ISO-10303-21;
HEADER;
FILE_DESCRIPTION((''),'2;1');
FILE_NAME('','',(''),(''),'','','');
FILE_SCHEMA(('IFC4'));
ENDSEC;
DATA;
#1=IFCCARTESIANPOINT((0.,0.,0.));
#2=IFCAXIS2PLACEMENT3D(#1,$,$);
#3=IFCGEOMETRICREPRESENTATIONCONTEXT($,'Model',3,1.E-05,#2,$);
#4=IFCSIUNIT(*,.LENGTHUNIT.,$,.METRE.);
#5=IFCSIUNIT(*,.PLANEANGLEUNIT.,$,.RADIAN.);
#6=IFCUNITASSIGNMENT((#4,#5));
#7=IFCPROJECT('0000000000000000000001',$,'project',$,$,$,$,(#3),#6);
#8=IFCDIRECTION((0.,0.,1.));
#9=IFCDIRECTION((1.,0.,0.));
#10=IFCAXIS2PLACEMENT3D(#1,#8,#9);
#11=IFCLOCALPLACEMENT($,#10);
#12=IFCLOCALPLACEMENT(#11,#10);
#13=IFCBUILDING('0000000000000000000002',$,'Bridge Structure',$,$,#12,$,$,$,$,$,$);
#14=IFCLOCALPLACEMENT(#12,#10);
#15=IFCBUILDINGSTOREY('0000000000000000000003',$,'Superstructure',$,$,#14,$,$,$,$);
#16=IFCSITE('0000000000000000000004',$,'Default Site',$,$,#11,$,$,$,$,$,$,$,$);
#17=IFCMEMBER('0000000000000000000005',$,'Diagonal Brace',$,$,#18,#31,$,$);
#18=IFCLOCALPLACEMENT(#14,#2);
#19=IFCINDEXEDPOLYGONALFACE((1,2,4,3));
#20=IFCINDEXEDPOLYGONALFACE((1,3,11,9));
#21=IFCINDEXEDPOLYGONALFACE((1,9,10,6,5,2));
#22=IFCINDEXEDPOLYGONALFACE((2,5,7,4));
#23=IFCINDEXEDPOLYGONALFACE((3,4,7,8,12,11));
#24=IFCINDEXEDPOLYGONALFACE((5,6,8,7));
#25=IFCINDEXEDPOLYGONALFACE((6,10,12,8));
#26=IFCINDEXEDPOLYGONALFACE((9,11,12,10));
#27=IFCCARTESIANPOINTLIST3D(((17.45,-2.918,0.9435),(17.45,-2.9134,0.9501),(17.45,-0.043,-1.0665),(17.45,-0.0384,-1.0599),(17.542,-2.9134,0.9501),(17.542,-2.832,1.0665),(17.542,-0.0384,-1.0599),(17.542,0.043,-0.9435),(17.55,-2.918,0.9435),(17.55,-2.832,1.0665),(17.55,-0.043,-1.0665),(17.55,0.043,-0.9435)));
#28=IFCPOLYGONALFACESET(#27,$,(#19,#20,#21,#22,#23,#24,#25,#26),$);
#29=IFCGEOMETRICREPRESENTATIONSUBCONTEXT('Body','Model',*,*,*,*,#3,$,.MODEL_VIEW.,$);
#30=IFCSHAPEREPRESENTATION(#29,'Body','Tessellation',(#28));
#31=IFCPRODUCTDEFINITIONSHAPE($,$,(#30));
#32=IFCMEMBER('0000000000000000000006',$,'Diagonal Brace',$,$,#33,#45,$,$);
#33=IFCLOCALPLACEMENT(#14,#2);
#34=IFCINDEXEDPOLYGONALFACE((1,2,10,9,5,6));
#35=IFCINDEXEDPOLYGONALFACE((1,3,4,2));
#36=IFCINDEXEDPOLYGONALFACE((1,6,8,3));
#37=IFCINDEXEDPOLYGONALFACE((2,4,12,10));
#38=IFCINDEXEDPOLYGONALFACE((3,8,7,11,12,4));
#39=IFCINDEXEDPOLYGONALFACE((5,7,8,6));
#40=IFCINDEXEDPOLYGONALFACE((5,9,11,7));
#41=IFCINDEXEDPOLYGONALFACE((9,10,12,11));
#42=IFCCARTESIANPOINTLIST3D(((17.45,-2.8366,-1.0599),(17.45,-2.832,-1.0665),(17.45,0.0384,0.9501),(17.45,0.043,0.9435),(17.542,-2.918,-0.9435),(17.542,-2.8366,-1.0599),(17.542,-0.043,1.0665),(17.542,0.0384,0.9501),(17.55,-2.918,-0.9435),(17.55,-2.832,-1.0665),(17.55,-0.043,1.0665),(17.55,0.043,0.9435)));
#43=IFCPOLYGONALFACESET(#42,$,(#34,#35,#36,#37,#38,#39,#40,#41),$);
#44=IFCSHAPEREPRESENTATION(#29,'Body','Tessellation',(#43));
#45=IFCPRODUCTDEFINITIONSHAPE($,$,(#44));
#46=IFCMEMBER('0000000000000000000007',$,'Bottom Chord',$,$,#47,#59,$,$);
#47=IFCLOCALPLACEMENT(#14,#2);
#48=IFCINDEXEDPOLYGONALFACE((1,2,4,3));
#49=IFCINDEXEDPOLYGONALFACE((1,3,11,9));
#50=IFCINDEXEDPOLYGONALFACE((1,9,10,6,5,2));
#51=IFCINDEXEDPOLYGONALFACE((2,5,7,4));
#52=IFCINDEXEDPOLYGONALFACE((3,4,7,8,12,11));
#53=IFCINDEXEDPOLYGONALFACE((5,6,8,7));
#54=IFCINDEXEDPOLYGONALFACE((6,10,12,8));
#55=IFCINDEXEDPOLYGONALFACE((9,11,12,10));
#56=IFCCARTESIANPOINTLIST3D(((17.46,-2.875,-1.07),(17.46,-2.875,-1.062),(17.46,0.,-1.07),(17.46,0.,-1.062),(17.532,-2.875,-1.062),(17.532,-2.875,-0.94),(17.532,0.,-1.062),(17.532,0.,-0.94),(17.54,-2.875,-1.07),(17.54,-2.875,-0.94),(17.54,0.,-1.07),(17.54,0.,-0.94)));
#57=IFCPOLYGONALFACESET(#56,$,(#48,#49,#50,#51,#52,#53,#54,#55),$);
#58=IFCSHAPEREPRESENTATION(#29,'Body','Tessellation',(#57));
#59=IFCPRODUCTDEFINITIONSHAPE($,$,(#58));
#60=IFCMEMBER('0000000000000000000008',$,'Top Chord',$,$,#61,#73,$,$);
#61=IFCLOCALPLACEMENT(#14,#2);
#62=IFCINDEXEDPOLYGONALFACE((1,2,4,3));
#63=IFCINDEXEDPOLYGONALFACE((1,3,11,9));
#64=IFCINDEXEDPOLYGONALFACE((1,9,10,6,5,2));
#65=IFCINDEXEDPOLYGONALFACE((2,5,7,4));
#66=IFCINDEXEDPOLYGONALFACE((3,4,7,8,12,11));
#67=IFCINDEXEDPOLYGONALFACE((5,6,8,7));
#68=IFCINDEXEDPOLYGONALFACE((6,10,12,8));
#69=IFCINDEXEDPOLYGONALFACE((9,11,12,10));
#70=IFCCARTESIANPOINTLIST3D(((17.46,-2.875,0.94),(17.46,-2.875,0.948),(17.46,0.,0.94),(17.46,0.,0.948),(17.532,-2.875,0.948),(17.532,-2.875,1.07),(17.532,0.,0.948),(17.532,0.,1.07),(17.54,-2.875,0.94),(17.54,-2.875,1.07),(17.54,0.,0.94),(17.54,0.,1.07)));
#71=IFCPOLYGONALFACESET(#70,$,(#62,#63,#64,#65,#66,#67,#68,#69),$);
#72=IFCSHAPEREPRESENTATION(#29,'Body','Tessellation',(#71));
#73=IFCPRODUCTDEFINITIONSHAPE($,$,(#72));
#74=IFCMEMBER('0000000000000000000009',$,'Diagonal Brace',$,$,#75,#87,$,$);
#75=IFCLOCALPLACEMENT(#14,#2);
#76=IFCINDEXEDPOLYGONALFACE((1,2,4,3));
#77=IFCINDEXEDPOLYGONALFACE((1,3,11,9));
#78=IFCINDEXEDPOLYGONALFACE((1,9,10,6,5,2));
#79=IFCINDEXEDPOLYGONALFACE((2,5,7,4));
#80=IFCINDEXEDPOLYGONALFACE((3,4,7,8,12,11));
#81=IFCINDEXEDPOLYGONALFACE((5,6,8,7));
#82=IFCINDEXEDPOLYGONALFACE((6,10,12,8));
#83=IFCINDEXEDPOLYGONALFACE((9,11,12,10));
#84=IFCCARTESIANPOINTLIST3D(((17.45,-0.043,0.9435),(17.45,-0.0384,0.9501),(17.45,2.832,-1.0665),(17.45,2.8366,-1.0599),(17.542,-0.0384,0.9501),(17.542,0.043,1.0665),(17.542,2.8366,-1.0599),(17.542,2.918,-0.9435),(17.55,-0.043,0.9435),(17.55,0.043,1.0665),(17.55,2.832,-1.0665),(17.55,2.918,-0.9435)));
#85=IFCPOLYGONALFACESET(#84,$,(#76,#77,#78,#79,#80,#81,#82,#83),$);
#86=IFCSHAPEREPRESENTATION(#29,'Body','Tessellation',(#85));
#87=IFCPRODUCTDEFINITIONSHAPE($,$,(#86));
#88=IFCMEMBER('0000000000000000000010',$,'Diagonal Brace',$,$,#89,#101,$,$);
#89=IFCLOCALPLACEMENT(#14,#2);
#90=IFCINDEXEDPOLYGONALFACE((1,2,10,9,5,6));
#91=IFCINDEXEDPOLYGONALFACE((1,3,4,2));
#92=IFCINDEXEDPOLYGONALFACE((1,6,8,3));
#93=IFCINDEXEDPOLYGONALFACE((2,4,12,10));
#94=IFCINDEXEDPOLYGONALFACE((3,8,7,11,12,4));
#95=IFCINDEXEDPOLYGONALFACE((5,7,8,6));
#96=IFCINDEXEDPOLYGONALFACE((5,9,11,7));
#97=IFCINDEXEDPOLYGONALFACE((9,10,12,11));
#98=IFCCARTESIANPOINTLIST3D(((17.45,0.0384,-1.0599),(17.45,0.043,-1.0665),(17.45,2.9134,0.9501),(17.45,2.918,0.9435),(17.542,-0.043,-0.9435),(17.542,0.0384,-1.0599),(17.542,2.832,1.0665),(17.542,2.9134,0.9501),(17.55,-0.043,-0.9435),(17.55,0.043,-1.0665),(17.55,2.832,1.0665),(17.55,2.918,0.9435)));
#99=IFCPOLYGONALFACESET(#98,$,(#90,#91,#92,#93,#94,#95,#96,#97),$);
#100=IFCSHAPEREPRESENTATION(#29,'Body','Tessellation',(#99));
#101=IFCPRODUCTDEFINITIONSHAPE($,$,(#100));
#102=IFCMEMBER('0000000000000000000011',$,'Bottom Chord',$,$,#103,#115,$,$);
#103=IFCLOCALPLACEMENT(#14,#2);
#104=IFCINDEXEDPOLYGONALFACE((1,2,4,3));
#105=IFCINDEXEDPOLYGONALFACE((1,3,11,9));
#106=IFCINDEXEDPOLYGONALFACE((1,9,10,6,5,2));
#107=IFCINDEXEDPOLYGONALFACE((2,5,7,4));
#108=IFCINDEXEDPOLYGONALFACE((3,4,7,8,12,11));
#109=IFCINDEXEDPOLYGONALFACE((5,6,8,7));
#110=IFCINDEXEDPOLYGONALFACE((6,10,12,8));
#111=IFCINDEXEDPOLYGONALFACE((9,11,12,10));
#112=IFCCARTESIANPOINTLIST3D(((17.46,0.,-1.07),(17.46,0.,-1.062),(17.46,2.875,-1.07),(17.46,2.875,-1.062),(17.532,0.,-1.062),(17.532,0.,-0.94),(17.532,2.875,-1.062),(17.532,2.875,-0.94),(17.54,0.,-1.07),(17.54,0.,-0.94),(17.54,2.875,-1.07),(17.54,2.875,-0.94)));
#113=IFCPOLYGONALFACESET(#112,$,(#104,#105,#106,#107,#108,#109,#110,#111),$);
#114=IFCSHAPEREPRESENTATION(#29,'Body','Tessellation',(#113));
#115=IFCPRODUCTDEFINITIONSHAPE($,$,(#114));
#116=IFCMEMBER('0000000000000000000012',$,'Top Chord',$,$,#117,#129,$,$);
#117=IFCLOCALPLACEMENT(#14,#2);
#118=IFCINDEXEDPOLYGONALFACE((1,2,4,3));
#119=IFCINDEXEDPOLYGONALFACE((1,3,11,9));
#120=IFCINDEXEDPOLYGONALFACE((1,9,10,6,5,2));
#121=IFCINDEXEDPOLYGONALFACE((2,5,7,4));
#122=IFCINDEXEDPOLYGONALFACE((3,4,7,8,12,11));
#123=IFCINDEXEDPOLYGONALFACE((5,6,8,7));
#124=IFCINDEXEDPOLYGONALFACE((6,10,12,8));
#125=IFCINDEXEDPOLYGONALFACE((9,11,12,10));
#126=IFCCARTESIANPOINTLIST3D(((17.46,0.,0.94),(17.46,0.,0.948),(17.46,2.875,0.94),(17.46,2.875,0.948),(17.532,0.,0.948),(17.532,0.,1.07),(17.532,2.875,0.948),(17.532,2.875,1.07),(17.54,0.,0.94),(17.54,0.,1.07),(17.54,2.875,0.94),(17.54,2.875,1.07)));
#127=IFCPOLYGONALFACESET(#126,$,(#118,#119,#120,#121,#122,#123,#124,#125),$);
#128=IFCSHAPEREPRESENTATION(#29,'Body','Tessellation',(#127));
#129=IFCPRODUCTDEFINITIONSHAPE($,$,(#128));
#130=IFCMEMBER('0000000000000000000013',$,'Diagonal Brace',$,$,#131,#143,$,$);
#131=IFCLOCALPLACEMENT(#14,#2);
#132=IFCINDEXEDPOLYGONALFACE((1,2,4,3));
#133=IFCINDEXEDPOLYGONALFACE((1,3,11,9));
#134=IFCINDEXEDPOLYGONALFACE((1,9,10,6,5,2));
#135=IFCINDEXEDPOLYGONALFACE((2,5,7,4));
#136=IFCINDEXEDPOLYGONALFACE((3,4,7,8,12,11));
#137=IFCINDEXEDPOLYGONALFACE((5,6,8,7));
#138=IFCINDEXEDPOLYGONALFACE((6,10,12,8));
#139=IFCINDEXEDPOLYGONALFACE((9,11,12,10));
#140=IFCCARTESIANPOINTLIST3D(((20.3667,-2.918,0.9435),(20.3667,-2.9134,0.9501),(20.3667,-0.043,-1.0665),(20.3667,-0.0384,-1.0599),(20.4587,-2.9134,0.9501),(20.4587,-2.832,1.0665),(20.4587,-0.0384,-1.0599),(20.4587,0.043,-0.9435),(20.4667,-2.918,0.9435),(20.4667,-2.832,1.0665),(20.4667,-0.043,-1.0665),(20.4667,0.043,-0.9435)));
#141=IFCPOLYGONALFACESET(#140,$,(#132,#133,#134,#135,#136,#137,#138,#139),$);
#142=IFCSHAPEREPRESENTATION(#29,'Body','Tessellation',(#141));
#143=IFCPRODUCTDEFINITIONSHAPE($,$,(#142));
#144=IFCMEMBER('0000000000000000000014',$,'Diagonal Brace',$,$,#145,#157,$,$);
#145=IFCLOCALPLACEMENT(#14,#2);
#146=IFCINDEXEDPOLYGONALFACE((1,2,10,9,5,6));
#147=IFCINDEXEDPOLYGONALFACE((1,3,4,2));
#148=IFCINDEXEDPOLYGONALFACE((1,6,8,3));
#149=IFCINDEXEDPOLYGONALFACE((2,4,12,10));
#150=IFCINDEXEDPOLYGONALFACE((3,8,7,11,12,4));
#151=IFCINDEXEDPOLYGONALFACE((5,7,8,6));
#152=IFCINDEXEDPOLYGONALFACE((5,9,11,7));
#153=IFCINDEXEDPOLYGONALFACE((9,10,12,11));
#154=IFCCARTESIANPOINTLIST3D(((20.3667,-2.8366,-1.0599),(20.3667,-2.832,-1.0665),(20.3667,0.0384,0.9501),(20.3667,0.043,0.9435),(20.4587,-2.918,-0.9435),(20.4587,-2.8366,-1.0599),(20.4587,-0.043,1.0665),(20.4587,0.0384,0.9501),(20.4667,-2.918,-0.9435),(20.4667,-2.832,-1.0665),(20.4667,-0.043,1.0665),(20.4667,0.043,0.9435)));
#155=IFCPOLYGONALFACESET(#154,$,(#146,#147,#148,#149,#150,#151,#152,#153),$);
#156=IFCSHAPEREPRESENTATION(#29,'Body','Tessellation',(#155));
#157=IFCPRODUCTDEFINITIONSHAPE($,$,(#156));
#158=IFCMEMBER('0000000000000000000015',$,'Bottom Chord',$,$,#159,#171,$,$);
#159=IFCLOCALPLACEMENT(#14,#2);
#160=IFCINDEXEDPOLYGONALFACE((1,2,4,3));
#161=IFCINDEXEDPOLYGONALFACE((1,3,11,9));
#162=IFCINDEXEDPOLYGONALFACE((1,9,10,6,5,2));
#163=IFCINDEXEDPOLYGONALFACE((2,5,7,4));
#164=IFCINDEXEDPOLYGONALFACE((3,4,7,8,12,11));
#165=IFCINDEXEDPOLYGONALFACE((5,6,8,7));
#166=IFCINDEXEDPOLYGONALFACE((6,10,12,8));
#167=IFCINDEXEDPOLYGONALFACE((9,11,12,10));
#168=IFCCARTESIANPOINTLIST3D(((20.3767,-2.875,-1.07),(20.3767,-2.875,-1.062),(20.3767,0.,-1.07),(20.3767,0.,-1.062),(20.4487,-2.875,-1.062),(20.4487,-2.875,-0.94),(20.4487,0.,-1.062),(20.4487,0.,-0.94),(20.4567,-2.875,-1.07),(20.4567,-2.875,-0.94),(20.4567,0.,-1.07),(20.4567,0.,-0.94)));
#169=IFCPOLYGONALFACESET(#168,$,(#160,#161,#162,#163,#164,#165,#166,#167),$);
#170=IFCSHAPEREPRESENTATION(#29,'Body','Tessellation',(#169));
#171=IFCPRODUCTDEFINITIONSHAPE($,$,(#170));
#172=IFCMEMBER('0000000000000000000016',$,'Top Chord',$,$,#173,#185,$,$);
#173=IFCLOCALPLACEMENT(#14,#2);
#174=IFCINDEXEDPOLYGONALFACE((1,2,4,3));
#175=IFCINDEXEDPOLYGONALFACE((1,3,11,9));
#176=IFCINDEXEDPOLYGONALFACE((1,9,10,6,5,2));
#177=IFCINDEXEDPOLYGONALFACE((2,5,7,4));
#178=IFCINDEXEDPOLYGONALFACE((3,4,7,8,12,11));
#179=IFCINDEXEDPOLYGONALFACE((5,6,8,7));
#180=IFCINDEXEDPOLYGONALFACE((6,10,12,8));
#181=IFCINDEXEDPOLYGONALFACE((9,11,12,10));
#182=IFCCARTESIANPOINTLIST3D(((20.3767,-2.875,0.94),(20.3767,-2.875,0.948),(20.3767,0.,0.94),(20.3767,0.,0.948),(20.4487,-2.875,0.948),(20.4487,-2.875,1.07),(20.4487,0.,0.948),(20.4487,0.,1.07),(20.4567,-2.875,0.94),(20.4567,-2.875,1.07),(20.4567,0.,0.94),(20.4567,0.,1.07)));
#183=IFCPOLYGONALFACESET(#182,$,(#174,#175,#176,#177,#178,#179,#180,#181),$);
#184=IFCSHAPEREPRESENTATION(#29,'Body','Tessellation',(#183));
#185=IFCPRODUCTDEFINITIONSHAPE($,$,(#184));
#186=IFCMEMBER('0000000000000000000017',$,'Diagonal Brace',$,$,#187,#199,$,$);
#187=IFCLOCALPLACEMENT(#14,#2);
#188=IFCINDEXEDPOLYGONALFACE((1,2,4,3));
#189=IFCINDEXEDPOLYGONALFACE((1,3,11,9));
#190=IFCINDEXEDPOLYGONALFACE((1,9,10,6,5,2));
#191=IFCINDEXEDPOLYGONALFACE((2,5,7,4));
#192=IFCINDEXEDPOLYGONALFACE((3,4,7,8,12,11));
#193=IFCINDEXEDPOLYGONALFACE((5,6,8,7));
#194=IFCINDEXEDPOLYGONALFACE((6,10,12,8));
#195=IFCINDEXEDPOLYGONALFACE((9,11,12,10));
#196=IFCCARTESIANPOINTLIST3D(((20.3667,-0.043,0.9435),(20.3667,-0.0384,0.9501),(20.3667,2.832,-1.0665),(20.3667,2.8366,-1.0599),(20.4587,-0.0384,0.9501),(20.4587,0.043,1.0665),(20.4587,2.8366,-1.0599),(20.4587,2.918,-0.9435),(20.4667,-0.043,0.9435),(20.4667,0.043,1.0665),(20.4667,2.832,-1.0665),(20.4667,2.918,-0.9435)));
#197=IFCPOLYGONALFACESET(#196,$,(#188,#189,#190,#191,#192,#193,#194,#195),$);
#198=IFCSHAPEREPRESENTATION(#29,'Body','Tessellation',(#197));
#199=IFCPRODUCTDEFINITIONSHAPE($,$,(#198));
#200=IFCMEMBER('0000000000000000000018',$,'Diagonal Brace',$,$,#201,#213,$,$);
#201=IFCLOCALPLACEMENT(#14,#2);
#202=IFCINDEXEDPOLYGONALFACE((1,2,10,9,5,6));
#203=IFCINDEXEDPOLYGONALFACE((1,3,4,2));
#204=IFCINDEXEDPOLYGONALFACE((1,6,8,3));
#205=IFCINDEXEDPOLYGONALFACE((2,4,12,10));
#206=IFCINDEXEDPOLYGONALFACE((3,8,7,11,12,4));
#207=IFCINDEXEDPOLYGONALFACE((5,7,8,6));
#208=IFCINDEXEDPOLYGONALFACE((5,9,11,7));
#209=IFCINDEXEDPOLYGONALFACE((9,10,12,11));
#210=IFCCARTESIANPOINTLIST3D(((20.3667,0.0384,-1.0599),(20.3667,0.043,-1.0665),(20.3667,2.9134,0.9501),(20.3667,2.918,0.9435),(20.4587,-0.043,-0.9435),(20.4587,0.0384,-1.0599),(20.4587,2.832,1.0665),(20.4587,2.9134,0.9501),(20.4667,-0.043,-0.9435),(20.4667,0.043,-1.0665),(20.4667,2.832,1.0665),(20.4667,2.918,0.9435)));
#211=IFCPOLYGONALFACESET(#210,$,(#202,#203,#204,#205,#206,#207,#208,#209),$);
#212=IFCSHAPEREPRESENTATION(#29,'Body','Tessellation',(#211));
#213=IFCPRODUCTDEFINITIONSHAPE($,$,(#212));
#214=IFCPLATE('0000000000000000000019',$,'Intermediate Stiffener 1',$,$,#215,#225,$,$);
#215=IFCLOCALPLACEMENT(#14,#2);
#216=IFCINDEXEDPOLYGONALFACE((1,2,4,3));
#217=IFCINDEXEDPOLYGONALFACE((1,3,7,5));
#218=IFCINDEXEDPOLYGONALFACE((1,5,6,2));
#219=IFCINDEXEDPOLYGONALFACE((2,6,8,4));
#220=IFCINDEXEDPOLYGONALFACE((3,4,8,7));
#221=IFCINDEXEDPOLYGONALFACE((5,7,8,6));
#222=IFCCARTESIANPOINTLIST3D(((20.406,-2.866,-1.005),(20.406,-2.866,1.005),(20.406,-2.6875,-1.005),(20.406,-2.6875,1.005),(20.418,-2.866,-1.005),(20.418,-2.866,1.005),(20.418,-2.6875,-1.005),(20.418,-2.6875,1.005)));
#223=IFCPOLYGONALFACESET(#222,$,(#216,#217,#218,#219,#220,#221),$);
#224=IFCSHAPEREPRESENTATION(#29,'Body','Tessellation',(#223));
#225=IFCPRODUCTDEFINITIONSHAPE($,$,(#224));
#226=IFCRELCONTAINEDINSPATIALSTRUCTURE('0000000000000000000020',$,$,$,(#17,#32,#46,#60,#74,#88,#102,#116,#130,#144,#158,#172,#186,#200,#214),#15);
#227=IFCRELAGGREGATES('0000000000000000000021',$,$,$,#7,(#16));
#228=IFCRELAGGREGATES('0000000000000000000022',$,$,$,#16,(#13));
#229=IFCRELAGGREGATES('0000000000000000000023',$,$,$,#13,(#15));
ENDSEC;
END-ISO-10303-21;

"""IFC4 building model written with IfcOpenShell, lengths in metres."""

from ifc_helpers import new_model, si_unit, frame, origin, origin_with_axes, origin_2d_with_axis, place, context, subcontext, project, spatial, rectangle, l_section, extrude, element, save


model = new_model("IFC4")

# Units and contexts
model_context = context("Model", 3, precision=1e-05, world=origin())
body_context = subcontext(model_context, "Body", "Model", "MODEL_VIEW")
ifc_project = project(units=[si_unit("LENGTHUNIT", "METRE"), si_unit("PLANEANGLEUNIT", "RADIAN")], contexts=[model_context])

# Site, building, storey
site_placement = place(None, origin_with_axes())
site = spatial("IfcSite", under=ifc_project, at=site_placement, Name="Default Site")
building_placement = place(site_placement, origin_with_axes())
building = spatial("IfcBuilding", under=site, at=building_placement, Name="Bridge Structure")
storey_placement = place(building_placement, origin_with_axes())
storey = spatial("IfcBuildingStorey", under=building, at=storey_placement, Name="Superstructure")

# Members
for number, where, z_axis, x_axis, name in (
    (1, (17.5, -2.875, 1.005), (0.0, 0.819567, -0.572984), (-1.0, 0.0, 0.0), "Diagonal Brace"),
    (2, (17.5, -2.875, -1.005), (0.0, 0.819567, 0.572984), (-1.0, 0.0, 0.0), "Diagonal Brace"),
):
    element("IfcMember", number, at=place(storey_placement, frame(where, z_axis=z_axis, x_axis=x_axis)), inside=storey, Name=name, context=body_context, shape_type="SweptSolid", body=[
        extrude(l_section(Depth=0.15, Width=0.1, Thickness=0.008, at=origin_2d_with_axis()), origin_with_axes(), (0.0, 0.0, 1.0), 3.508),
    ])
for number, where, z_axis, x_axis, name in (
    (3, (17.5, -2.875, -1.005), (0.0, 1.0, 0.0), (-1.0, 0.0, 0.0), "Bottom Chord"),
    (4, (17.5, -2.875, 1.005), (0.0, 1.0, 0.0), (-1.0, 0.0, 0.0), "Top Chord"),
):
    element("IfcMember", number, at=place(storey_placement, frame(where, z_axis=z_axis, x_axis=x_axis)), inside=storey, Name=name, context=body_context, shape_type="SweptSolid", body=[
        extrude(l_section(Depth=0.13, Width=0.08, Thickness=0.008, at=origin_2d_with_axis()), origin_with_axes(), (0.0, 0.0, 1.0), 2.875),
    ])
for number, where, z_axis, x_axis, name in (
    (5, (17.5, 0.0, 1.005), (0.0, 0.819567, -0.572984), (-1.0, 0.0, 0.0), "Diagonal Brace"),
    (6, (17.5, 0.0, -1.005), (0.0, 0.819567, 0.572984), (-1.0, 0.0, 0.0), "Diagonal Brace"),
):
    element("IfcMember", number, at=place(storey_placement, frame(where, z_axis=z_axis, x_axis=x_axis)), inside=storey, Name=name, context=body_context, shape_type="SweptSolid", body=[
        extrude(l_section(Depth=0.15, Width=0.1, Thickness=0.008, at=origin_2d_with_axis()), origin_with_axes(), (0.0, 0.0, 1.0), 3.508),
    ])
for number, where, z_axis, x_axis, name in (
    (7, (17.5, 0.0, -1.005), (0.0, 1.0, 0.0), (-1.0, 0.0, 0.0), "Bottom Chord"),
    (8, (17.5, 0.0, 1.005), (0.0, 1.0, 0.0), (-1.0, 0.0, 0.0), "Top Chord"),
):
    element("IfcMember", number, at=place(storey_placement, frame(where, z_axis=z_axis, x_axis=x_axis)), inside=storey, Name=name, context=body_context, shape_type="SweptSolid", body=[
        extrude(l_section(Depth=0.13, Width=0.08, Thickness=0.008, at=origin_2d_with_axis()), origin_with_axes(), (0.0, 0.0, 1.0), 2.875),
    ])
for number, where, z_axis, x_axis, name in (
    (9, (20.4167, -2.875, 1.005), (0.0, 0.819567, -0.572984), (-1.0, 0.0, 0.0), "Diagonal Brace"),
    (10, (20.4167, -2.875, -1.005), (0.0, 0.819567, 0.572984), (-1.0, 0.0, 0.0), "Diagonal Brace"),
):
    element("IfcMember", number, at=place(storey_placement, frame(where, z_axis=z_axis, x_axis=x_axis)), inside=storey, Name=name, context=body_context, shape_type="SweptSolid", body=[
        extrude(l_section(Depth=0.15, Width=0.1, Thickness=0.008, at=origin_2d_with_axis()), origin_with_axes(), (0.0, 0.0, 1.0), 3.508),
    ])
for number, where, z_axis, x_axis, name in (
    (11, (20.4167, -2.875, -1.005), (0.0, 1.0, 0.0), (-1.0, 0.0, 0.0), "Bottom Chord"),
    (12, (20.4167, -2.875, 1.005), (0.0, 1.0, 0.0), (-1.0, 0.0, 0.0), "Top Chord"),
):
    element("IfcMember", number, at=place(storey_placement, frame(where, z_axis=z_axis, x_axis=x_axis)), inside=storey, Name=name, context=body_context, shape_type="SweptSolid", body=[
        extrude(l_section(Depth=0.13, Width=0.08, Thickness=0.008, at=origin_2d_with_axis()), origin_with_axes(), (0.0, 0.0, 1.0), 2.875),
    ])
for number, where, z_axis, x_axis, name in (
    (13, (20.4167, 0.0, 1.005), (0.0, 0.819567, -0.572984), (-1.0, 0.0, 0.0), "Diagonal Brace"),
    (14, (20.4167, 0.0, -1.005), (0.0, 0.819567, 0.572984), (-1.0, 0.0, 0.0), "Diagonal Brace"),
):
    element("IfcMember", number, at=place(storey_placement, frame(where, z_axis=z_axis, x_axis=x_axis)), inside=storey, Name=name, context=body_context, shape_type="SweptSolid", body=[
        extrude(l_section(Depth=0.15, Width=0.1, Thickness=0.008, at=origin_2d_with_axis()), origin_with_axes(), (0.0, 0.0, 1.0), 3.508),
    ])

# Plate
for number, where, z_axis, x_axis, name in (
    (15, (20.412, -2.7768, -1.005), (0.0, 0.0, 1.0), (1.0, 0.0, 0.0), "Intermediate Stiffener 1"),
):
    element("IfcPlate", number, at=place(storey_placement, frame(where, z_axis=z_axis, x_axis=x_axis)), inside=storey, Name=name, context=body_context, shape_type="SweptSolid", body=[
        extrude(rectangle(XDim=0.012, YDim=0.1785, at=origin_2d_with_axis()), origin_with_axes(), (0.0, 0.0, 1.0), 2.01),
    ])

save(model, "model.ifc")
